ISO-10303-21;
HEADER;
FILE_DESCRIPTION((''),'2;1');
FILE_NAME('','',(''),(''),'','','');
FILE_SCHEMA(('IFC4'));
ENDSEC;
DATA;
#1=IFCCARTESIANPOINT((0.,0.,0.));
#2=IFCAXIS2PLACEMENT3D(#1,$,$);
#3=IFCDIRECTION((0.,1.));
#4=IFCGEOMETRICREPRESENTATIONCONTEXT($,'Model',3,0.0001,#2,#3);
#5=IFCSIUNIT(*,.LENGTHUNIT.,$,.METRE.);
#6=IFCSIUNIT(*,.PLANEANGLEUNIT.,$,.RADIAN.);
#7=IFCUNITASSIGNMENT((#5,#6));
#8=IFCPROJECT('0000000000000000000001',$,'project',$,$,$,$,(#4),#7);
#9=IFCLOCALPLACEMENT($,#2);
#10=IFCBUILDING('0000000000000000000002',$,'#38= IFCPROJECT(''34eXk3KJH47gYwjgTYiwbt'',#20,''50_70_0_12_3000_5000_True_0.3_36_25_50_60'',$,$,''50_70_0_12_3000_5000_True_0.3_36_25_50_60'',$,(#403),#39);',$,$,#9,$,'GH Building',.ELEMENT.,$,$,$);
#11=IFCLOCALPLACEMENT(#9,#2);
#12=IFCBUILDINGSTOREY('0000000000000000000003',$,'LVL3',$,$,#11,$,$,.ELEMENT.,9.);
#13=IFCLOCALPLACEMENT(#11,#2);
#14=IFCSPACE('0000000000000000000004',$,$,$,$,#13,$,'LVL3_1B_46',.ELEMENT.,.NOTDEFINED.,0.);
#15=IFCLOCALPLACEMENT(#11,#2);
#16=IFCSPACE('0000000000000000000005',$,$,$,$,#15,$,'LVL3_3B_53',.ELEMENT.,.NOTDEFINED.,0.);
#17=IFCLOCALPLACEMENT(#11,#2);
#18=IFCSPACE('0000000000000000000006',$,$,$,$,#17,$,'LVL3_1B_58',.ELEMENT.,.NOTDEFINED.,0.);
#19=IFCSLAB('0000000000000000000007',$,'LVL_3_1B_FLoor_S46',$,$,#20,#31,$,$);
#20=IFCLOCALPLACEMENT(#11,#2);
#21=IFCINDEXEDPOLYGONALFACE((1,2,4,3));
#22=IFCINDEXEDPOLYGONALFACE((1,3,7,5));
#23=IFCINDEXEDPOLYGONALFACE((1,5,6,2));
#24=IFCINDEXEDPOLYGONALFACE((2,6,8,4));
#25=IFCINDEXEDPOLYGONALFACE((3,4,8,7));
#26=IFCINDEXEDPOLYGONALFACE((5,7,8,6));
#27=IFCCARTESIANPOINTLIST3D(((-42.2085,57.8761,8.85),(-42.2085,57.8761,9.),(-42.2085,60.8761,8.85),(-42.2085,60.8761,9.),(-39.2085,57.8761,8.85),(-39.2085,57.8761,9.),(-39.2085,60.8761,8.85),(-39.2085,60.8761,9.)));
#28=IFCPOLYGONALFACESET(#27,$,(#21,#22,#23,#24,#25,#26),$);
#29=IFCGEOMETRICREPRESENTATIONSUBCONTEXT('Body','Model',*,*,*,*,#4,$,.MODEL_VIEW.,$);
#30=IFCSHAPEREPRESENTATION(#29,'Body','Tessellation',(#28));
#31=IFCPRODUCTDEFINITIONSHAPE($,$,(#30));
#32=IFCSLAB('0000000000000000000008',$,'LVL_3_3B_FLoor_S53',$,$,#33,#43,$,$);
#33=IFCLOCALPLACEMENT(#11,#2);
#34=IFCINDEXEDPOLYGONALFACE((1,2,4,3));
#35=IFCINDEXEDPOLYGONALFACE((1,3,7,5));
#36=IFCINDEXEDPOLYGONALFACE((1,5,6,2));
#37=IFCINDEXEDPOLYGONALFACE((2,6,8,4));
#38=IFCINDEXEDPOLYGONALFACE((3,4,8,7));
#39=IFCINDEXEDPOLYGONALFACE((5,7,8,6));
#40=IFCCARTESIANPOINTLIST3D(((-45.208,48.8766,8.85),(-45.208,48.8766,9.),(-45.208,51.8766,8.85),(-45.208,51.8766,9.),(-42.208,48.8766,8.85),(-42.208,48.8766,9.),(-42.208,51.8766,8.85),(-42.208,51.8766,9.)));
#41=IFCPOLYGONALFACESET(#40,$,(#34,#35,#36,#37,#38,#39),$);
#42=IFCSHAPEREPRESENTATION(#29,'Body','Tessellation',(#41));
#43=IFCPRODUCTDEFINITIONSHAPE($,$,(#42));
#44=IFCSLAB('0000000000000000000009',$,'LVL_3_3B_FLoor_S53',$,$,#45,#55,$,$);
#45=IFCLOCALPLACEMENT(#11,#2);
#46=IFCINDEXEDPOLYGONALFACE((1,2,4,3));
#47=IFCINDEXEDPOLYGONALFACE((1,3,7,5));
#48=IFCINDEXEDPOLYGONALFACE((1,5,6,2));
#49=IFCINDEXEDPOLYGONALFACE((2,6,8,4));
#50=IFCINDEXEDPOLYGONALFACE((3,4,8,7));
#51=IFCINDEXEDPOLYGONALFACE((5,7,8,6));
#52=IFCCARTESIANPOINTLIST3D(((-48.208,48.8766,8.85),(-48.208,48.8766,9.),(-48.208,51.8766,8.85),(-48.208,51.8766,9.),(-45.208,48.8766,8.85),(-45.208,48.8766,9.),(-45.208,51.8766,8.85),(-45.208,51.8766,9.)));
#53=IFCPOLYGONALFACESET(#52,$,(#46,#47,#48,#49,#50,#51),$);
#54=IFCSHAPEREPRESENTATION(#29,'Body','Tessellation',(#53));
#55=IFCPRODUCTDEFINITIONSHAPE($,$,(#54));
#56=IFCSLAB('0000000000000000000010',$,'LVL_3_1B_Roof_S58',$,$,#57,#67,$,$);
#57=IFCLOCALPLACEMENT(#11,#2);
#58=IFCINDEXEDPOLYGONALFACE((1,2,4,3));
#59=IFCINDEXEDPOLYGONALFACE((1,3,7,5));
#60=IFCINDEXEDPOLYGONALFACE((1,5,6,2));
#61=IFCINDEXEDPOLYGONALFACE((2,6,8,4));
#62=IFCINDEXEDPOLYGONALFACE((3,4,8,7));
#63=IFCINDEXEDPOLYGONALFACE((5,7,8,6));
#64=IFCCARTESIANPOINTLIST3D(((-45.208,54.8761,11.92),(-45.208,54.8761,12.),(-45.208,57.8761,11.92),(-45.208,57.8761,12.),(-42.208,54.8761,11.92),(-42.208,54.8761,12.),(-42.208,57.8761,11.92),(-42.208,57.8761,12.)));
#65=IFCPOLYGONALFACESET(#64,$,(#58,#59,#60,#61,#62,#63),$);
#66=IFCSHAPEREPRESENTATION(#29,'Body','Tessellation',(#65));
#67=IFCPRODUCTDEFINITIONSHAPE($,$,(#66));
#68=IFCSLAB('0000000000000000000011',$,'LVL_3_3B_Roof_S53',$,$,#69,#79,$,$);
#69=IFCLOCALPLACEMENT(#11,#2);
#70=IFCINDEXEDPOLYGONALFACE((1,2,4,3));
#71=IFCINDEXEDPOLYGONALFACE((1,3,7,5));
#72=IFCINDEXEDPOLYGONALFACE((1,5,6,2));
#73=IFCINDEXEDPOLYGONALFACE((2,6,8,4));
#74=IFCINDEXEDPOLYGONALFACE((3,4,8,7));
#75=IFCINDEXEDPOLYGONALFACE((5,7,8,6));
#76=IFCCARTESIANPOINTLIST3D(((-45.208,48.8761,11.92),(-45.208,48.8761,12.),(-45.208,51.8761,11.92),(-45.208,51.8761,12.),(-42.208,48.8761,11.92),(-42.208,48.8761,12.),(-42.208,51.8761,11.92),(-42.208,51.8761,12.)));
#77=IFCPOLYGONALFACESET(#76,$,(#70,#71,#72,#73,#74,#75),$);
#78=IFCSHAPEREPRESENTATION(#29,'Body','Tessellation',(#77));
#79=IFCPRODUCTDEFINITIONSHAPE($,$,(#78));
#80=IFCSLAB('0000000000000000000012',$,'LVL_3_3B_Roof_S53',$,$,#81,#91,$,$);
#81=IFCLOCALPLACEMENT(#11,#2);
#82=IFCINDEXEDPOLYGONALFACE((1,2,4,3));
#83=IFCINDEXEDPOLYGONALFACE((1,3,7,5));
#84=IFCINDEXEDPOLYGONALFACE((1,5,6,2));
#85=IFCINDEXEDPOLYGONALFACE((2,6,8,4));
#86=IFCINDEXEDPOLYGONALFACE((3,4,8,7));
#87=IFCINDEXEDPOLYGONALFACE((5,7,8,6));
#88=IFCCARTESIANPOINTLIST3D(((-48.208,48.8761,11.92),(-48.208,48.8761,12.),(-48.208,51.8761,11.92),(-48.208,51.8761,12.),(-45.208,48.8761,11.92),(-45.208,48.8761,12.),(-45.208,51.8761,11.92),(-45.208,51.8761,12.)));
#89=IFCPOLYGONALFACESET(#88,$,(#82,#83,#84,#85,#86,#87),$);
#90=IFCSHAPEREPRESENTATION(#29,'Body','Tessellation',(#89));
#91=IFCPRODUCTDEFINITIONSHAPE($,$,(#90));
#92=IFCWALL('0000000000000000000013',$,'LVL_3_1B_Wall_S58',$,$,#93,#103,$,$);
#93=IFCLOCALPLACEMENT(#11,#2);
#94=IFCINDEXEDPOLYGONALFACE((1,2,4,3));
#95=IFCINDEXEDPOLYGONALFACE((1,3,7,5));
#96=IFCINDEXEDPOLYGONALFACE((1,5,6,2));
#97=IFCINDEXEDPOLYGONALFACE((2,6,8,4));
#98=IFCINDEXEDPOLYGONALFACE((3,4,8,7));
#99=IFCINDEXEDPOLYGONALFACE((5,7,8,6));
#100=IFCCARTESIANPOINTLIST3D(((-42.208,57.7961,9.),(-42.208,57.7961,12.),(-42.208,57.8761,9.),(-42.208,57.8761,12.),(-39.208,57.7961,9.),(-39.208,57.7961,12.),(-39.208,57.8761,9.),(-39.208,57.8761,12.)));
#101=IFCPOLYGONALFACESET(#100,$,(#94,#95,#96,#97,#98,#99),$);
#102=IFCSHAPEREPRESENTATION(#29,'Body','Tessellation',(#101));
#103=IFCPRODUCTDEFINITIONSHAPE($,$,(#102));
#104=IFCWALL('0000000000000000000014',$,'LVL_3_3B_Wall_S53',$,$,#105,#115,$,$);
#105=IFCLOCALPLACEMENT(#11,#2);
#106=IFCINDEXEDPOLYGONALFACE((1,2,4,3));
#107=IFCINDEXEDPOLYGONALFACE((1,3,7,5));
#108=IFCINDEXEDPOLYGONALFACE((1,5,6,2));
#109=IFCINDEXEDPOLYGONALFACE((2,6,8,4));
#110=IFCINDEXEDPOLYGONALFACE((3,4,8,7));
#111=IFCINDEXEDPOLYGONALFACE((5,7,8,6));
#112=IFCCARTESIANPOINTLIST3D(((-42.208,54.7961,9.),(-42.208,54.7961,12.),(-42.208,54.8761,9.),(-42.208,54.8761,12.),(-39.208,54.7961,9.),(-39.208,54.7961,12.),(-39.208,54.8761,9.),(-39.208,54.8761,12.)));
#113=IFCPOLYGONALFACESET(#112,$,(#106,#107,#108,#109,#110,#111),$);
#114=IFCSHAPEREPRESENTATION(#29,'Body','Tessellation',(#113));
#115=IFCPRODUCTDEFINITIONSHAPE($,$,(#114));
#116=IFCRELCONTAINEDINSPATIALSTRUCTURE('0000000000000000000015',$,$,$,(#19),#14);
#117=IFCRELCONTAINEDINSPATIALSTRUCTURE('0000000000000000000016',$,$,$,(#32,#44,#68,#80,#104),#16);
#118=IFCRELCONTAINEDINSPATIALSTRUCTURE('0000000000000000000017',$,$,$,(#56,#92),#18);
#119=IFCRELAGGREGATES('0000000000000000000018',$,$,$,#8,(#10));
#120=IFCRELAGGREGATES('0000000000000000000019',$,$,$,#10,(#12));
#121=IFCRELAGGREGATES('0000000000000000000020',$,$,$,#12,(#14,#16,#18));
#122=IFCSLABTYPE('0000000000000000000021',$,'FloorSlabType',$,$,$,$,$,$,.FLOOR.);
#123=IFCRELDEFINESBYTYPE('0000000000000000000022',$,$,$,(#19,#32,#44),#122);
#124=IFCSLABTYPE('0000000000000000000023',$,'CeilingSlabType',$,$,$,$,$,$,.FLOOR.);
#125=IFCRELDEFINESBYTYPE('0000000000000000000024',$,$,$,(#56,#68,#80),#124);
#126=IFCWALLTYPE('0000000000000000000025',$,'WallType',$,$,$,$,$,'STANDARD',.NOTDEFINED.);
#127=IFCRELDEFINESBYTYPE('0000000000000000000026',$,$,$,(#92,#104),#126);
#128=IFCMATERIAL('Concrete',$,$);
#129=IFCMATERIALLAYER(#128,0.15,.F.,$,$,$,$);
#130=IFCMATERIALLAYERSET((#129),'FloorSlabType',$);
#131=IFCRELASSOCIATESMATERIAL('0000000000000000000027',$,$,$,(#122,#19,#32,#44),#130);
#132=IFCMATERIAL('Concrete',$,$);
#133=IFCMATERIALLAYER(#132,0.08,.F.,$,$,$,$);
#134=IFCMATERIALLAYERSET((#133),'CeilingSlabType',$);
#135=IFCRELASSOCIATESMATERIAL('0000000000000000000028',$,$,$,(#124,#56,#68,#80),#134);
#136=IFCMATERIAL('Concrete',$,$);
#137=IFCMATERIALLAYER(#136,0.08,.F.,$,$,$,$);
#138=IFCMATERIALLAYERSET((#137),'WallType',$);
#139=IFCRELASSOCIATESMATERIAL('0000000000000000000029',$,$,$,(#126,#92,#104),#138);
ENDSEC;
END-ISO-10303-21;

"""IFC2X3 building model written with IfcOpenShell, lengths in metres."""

from ifc_helpers import new_model, si_unit, direction, frame, frame_2d, origin, place, context, subcontext, project, spatial, rectangle, extrude, material, layer, layer_set, layer_usage, type_object, element, save


model = new_model("IFC2X3")

# Units and contexts
model_context = context("Model", 3, precision=0.0001, world=origin(), true_north=direction((0.0, 1.0)))
body_context = subcontext(model_context, "Body", "Model", "MODEL_VIEW")
ifc_project = project(units=[si_unit("LENGTHUNIT", "METRE"), si_unit("PLANEANGLEUNIT", "RADIAN")], contexts=[model_context])

# Building, storey, space
building_placement = place(None, origin())
building = spatial("IfcBuilding", under=ifc_project, at=building_placement, Name="#38= IFCPROJECT('34eXk3KJH47gYwjgTYiwbt',#20,'50_70_0_12_3000_5000_True_0.3_36_25_50_60',$,$,'50_70_0_12_3000_5000_True_0.3_36_25_50_60',$,(#403),#39);", LongName="GH Building", CompositionType="ELEMENT")
storey_placement = place(building_placement, origin())
storey = spatial("IfcBuildingStorey", under=building, at=storey_placement, Name="LVL3", CompositionType="ELEMENT", Elevation=9.0)
space_1_placement = place(storey_placement, origin())
space_1 = spatial("IfcSpace", under=storey, at=space_1_placement, LongName="LVL3_1B_46", CompositionType="ELEMENT", InteriorOrExteriorSpace="NOTDEFINED", ElevationWithFlooring=0.0)

# Slab
ifc_material_1 = material(Name="Concrete")
ifc_layer_1 = layer(ifc_material_1, 0.15, ventilated=False)
ifc_layer_set_1 = layer_set([ifc_layer_1], Name="FloorSlabType")
ifc_layer_usage_1 = layer_usage(ifc_layer_set_1, "AXIS3", "NEGATIVE", -0.15)
slab_type_1 = type_object("IfcSlabType", Name="FloorSlabType", PredefinedType="FLOOR", material=ifc_layer_set_1)
slab_1_placement = place(space_1_placement, frame((-42.2085, 60.8761, 8.85), z_axis=(0.0, 0.0, 1.0), x_axis=(0.0, -1.0, 0.0)))
element("IfcSlab", 1, at=slab_1_placement, inside=space_1, type_object=slab_type_1, material=ifc_layer_usage_1, Name="LVL_3_1B_FLoor_S46", context=body_context, shape_type="SweptSolid", body=[
    extrude(rectangle(XDim=3.0, YDim=3.0, at=frame_2d((1.5, 1.5))), origin(), (0.0, 0.0, 1.0), 0.15),
])

# Shared definitions
space_2_placement = place(storey_placement, origin())
space_2 = spatial("IfcSpace", under=storey, at=space_2_placement, LongName="LVL3_3B_53", CompositionType="ELEMENT", InteriorOrExteriorSpace="NOTDEFINED", ElevationWithFlooring=0.0)

# Slabs
ifc_layer_usage_2 = layer_usage(ifc_layer_set_1, "AXIS3", "NEGATIVE", -0.15)
slab_2_placement = place(space_2_placement, frame((-42.208, 51.8766, 8.85), z_axis=(0.0, 0.0, 1.0), x_axis=(-1.0, 0.0, 0.0)))
element("IfcSlab", 2, at=slab_2_placement, inside=space_2, type_object=slab_type_1, material=ifc_layer_usage_2, Name="LVL_3_3B_FLoor_S53", context=body_context, shape_type="SweptSolid", body=[
    extrude(rectangle(XDim=3.0, YDim=3.0, at=frame_2d((1.5, 1.5))), origin(), (0.0, 0.0, 1.0), 0.15),
])
ifc_layer_usage_3 = layer_usage(ifc_layer_set_1, "AXIS3", "NEGATIVE", -0.15)
slab_3_placement = place(space_2_placement, frame((-45.208, 51.8766, 8.85), z_axis=(0.0, 0.0, 1.0), x_axis=(-1.0, 0.0, 0.0)))
element("IfcSlab", 3, at=slab_3_placement, inside=space_2, type_object=slab_type_1, material=ifc_layer_usage_3, Name="LVL_3_3B_FLoor_S53", context=body_context, shape_type="SweptSolid", body=[
    extrude(rectangle(XDim=3.0, YDim=3.0, at=frame_2d((1.5, 1.5))), origin(), (0.0, 0.0, 1.0), 0.15),
])

# Shared definitions
space_3_placement = place(storey_placement, origin())
space_3 = spatial("IfcSpace", under=storey, at=space_3_placement, LongName="LVL3_1B_58", CompositionType="ELEMENT", InteriorOrExteriorSpace="NOTDEFINED", ElevationWithFlooring=0.0)

# Slabs
ifc_material_2 = material(Name="Concrete")
ifc_layer_2 = layer(ifc_material_2, 0.08, ventilated=False)
ifc_layer_set_2 = layer_set([ifc_layer_2], Name="CeilingSlabType")
ifc_layer_usage_4 = layer_usage(ifc_layer_set_2, "AXIS3", "NEGATIVE", -0.08)
slab_type_2 = type_object("IfcSlabType", Name="CeilingSlabType", PredefinedType="FLOOR", material=ifc_layer_set_2)
slab_4_placement = place(space_3_placement, frame((-42.208, 57.8761, 11.92), z_axis=(0.0, 0.0, 1.0), x_axis=(-1.0, 0.0, 0.0)))
element("IfcSlab", 4, at=slab_4_placement, inside=space_3, type_object=slab_type_2, material=ifc_layer_usage_4, Name="LVL_3_1B_Roof_S58", context=body_context, shape_type="SweptSolid", body=[
    extrude(rectangle(XDim=3.0, YDim=3.0, at=frame_2d((1.5, 1.5))), origin(), (0.0, 0.0, 1.0), 0.08),
])
ifc_layer_usage_5 = layer_usage(ifc_layer_set_2, "AXIS3", "NEGATIVE", -0.08)
slab_5_placement = place(space_2_placement, frame((-42.208, 51.8761, 11.92), z_axis=(0.0, 0.0, 1.0), x_axis=(-1.0, 0.0, 0.0)))
element("IfcSlab", 5, at=slab_5_placement, inside=space_2, type_object=slab_type_2, material=ifc_layer_usage_5, Name="LVL_3_3B_Roof_S53", context=body_context, shape_type="SweptSolid", body=[
    extrude(rectangle(XDim=3.0, YDim=3.0, at=frame_2d((1.5, 1.5))), origin(), (0.0, 0.0, 1.0), 0.08),
])
ifc_layer_usage_6 = layer_usage(ifc_layer_set_2, "AXIS3", "NEGATIVE", -0.08)
slab_6_placement = place(space_2_placement, frame((-48.208, 51.8761, 11.92)))
element("IfcSlab", 6, at=slab_6_placement, inside=space_2, type_object=slab_type_2, material=ifc_layer_usage_6, Name="LVL_3_3B_Roof_S53", context=body_context, shape_type="SweptSolid", body=[
    extrude(rectangle(XDim=3.0, YDim=3.0, at=frame_2d((1.5, -1.5))), origin(), (0.0, 0.0, 1.0), 0.08),
])

# Shared definitions
ifc_material_3 = material(Name="Concrete")
ifc_layer_3 = layer(ifc_material_3, 0.08, ventilated=False)
ifc_layer_set_3 = layer_set([ifc_layer_3], Name="WallType")
wall_type = type_object("IfcWallType", Name="WallType", ElementType="STANDARD", PredefinedType="NOTDEFINED", material=ifc_layer_set_3)

# Wall
ifc_layer_usage_7 = layer_usage(ifc_layer_set_3, "AXIS2", "NEGATIVE", 0.0)
wall_1_placement = place(space_3_placement, frame((-42.208, 57.8761, 9.0)))
element("IfcWall", 7, at=wall_1_placement, inside=space_3, type_object=wall_type, material=ifc_layer_usage_7, Name="LVL_3_1B_Wall_S58", context=body_context, shape_type="SweptSolid", body=[
    extrude(rectangle(XDim=3.0, YDim=0.08, at=frame_2d((1.5, -0.04))), origin(), (0.0, 0.0, 1.0), 3.0),
])

# Wall
ifc_layer_usage_8 = layer_usage(ifc_layer_set_3, "AXIS2", "NEGATIVE", 0.0)
wall_2_placement = place(space_2_placement, frame((-42.208, 54.8761, 9.0)))
element("IfcWall", 8, at=wall_2_placement, inside=space_2, type_object=wall_type, material=ifc_layer_usage_8, Name="LVL_3_3B_Wall_S53", context=body_context, shape_type="SweptSolid", body=[
    extrude(rectangle(XDim=3.0, YDim=0.08, at=frame_2d((1.5, -0.04))), origin(), (0.0, 0.0, 1.0), 3.0),
])

save(model, "model.ifc")
